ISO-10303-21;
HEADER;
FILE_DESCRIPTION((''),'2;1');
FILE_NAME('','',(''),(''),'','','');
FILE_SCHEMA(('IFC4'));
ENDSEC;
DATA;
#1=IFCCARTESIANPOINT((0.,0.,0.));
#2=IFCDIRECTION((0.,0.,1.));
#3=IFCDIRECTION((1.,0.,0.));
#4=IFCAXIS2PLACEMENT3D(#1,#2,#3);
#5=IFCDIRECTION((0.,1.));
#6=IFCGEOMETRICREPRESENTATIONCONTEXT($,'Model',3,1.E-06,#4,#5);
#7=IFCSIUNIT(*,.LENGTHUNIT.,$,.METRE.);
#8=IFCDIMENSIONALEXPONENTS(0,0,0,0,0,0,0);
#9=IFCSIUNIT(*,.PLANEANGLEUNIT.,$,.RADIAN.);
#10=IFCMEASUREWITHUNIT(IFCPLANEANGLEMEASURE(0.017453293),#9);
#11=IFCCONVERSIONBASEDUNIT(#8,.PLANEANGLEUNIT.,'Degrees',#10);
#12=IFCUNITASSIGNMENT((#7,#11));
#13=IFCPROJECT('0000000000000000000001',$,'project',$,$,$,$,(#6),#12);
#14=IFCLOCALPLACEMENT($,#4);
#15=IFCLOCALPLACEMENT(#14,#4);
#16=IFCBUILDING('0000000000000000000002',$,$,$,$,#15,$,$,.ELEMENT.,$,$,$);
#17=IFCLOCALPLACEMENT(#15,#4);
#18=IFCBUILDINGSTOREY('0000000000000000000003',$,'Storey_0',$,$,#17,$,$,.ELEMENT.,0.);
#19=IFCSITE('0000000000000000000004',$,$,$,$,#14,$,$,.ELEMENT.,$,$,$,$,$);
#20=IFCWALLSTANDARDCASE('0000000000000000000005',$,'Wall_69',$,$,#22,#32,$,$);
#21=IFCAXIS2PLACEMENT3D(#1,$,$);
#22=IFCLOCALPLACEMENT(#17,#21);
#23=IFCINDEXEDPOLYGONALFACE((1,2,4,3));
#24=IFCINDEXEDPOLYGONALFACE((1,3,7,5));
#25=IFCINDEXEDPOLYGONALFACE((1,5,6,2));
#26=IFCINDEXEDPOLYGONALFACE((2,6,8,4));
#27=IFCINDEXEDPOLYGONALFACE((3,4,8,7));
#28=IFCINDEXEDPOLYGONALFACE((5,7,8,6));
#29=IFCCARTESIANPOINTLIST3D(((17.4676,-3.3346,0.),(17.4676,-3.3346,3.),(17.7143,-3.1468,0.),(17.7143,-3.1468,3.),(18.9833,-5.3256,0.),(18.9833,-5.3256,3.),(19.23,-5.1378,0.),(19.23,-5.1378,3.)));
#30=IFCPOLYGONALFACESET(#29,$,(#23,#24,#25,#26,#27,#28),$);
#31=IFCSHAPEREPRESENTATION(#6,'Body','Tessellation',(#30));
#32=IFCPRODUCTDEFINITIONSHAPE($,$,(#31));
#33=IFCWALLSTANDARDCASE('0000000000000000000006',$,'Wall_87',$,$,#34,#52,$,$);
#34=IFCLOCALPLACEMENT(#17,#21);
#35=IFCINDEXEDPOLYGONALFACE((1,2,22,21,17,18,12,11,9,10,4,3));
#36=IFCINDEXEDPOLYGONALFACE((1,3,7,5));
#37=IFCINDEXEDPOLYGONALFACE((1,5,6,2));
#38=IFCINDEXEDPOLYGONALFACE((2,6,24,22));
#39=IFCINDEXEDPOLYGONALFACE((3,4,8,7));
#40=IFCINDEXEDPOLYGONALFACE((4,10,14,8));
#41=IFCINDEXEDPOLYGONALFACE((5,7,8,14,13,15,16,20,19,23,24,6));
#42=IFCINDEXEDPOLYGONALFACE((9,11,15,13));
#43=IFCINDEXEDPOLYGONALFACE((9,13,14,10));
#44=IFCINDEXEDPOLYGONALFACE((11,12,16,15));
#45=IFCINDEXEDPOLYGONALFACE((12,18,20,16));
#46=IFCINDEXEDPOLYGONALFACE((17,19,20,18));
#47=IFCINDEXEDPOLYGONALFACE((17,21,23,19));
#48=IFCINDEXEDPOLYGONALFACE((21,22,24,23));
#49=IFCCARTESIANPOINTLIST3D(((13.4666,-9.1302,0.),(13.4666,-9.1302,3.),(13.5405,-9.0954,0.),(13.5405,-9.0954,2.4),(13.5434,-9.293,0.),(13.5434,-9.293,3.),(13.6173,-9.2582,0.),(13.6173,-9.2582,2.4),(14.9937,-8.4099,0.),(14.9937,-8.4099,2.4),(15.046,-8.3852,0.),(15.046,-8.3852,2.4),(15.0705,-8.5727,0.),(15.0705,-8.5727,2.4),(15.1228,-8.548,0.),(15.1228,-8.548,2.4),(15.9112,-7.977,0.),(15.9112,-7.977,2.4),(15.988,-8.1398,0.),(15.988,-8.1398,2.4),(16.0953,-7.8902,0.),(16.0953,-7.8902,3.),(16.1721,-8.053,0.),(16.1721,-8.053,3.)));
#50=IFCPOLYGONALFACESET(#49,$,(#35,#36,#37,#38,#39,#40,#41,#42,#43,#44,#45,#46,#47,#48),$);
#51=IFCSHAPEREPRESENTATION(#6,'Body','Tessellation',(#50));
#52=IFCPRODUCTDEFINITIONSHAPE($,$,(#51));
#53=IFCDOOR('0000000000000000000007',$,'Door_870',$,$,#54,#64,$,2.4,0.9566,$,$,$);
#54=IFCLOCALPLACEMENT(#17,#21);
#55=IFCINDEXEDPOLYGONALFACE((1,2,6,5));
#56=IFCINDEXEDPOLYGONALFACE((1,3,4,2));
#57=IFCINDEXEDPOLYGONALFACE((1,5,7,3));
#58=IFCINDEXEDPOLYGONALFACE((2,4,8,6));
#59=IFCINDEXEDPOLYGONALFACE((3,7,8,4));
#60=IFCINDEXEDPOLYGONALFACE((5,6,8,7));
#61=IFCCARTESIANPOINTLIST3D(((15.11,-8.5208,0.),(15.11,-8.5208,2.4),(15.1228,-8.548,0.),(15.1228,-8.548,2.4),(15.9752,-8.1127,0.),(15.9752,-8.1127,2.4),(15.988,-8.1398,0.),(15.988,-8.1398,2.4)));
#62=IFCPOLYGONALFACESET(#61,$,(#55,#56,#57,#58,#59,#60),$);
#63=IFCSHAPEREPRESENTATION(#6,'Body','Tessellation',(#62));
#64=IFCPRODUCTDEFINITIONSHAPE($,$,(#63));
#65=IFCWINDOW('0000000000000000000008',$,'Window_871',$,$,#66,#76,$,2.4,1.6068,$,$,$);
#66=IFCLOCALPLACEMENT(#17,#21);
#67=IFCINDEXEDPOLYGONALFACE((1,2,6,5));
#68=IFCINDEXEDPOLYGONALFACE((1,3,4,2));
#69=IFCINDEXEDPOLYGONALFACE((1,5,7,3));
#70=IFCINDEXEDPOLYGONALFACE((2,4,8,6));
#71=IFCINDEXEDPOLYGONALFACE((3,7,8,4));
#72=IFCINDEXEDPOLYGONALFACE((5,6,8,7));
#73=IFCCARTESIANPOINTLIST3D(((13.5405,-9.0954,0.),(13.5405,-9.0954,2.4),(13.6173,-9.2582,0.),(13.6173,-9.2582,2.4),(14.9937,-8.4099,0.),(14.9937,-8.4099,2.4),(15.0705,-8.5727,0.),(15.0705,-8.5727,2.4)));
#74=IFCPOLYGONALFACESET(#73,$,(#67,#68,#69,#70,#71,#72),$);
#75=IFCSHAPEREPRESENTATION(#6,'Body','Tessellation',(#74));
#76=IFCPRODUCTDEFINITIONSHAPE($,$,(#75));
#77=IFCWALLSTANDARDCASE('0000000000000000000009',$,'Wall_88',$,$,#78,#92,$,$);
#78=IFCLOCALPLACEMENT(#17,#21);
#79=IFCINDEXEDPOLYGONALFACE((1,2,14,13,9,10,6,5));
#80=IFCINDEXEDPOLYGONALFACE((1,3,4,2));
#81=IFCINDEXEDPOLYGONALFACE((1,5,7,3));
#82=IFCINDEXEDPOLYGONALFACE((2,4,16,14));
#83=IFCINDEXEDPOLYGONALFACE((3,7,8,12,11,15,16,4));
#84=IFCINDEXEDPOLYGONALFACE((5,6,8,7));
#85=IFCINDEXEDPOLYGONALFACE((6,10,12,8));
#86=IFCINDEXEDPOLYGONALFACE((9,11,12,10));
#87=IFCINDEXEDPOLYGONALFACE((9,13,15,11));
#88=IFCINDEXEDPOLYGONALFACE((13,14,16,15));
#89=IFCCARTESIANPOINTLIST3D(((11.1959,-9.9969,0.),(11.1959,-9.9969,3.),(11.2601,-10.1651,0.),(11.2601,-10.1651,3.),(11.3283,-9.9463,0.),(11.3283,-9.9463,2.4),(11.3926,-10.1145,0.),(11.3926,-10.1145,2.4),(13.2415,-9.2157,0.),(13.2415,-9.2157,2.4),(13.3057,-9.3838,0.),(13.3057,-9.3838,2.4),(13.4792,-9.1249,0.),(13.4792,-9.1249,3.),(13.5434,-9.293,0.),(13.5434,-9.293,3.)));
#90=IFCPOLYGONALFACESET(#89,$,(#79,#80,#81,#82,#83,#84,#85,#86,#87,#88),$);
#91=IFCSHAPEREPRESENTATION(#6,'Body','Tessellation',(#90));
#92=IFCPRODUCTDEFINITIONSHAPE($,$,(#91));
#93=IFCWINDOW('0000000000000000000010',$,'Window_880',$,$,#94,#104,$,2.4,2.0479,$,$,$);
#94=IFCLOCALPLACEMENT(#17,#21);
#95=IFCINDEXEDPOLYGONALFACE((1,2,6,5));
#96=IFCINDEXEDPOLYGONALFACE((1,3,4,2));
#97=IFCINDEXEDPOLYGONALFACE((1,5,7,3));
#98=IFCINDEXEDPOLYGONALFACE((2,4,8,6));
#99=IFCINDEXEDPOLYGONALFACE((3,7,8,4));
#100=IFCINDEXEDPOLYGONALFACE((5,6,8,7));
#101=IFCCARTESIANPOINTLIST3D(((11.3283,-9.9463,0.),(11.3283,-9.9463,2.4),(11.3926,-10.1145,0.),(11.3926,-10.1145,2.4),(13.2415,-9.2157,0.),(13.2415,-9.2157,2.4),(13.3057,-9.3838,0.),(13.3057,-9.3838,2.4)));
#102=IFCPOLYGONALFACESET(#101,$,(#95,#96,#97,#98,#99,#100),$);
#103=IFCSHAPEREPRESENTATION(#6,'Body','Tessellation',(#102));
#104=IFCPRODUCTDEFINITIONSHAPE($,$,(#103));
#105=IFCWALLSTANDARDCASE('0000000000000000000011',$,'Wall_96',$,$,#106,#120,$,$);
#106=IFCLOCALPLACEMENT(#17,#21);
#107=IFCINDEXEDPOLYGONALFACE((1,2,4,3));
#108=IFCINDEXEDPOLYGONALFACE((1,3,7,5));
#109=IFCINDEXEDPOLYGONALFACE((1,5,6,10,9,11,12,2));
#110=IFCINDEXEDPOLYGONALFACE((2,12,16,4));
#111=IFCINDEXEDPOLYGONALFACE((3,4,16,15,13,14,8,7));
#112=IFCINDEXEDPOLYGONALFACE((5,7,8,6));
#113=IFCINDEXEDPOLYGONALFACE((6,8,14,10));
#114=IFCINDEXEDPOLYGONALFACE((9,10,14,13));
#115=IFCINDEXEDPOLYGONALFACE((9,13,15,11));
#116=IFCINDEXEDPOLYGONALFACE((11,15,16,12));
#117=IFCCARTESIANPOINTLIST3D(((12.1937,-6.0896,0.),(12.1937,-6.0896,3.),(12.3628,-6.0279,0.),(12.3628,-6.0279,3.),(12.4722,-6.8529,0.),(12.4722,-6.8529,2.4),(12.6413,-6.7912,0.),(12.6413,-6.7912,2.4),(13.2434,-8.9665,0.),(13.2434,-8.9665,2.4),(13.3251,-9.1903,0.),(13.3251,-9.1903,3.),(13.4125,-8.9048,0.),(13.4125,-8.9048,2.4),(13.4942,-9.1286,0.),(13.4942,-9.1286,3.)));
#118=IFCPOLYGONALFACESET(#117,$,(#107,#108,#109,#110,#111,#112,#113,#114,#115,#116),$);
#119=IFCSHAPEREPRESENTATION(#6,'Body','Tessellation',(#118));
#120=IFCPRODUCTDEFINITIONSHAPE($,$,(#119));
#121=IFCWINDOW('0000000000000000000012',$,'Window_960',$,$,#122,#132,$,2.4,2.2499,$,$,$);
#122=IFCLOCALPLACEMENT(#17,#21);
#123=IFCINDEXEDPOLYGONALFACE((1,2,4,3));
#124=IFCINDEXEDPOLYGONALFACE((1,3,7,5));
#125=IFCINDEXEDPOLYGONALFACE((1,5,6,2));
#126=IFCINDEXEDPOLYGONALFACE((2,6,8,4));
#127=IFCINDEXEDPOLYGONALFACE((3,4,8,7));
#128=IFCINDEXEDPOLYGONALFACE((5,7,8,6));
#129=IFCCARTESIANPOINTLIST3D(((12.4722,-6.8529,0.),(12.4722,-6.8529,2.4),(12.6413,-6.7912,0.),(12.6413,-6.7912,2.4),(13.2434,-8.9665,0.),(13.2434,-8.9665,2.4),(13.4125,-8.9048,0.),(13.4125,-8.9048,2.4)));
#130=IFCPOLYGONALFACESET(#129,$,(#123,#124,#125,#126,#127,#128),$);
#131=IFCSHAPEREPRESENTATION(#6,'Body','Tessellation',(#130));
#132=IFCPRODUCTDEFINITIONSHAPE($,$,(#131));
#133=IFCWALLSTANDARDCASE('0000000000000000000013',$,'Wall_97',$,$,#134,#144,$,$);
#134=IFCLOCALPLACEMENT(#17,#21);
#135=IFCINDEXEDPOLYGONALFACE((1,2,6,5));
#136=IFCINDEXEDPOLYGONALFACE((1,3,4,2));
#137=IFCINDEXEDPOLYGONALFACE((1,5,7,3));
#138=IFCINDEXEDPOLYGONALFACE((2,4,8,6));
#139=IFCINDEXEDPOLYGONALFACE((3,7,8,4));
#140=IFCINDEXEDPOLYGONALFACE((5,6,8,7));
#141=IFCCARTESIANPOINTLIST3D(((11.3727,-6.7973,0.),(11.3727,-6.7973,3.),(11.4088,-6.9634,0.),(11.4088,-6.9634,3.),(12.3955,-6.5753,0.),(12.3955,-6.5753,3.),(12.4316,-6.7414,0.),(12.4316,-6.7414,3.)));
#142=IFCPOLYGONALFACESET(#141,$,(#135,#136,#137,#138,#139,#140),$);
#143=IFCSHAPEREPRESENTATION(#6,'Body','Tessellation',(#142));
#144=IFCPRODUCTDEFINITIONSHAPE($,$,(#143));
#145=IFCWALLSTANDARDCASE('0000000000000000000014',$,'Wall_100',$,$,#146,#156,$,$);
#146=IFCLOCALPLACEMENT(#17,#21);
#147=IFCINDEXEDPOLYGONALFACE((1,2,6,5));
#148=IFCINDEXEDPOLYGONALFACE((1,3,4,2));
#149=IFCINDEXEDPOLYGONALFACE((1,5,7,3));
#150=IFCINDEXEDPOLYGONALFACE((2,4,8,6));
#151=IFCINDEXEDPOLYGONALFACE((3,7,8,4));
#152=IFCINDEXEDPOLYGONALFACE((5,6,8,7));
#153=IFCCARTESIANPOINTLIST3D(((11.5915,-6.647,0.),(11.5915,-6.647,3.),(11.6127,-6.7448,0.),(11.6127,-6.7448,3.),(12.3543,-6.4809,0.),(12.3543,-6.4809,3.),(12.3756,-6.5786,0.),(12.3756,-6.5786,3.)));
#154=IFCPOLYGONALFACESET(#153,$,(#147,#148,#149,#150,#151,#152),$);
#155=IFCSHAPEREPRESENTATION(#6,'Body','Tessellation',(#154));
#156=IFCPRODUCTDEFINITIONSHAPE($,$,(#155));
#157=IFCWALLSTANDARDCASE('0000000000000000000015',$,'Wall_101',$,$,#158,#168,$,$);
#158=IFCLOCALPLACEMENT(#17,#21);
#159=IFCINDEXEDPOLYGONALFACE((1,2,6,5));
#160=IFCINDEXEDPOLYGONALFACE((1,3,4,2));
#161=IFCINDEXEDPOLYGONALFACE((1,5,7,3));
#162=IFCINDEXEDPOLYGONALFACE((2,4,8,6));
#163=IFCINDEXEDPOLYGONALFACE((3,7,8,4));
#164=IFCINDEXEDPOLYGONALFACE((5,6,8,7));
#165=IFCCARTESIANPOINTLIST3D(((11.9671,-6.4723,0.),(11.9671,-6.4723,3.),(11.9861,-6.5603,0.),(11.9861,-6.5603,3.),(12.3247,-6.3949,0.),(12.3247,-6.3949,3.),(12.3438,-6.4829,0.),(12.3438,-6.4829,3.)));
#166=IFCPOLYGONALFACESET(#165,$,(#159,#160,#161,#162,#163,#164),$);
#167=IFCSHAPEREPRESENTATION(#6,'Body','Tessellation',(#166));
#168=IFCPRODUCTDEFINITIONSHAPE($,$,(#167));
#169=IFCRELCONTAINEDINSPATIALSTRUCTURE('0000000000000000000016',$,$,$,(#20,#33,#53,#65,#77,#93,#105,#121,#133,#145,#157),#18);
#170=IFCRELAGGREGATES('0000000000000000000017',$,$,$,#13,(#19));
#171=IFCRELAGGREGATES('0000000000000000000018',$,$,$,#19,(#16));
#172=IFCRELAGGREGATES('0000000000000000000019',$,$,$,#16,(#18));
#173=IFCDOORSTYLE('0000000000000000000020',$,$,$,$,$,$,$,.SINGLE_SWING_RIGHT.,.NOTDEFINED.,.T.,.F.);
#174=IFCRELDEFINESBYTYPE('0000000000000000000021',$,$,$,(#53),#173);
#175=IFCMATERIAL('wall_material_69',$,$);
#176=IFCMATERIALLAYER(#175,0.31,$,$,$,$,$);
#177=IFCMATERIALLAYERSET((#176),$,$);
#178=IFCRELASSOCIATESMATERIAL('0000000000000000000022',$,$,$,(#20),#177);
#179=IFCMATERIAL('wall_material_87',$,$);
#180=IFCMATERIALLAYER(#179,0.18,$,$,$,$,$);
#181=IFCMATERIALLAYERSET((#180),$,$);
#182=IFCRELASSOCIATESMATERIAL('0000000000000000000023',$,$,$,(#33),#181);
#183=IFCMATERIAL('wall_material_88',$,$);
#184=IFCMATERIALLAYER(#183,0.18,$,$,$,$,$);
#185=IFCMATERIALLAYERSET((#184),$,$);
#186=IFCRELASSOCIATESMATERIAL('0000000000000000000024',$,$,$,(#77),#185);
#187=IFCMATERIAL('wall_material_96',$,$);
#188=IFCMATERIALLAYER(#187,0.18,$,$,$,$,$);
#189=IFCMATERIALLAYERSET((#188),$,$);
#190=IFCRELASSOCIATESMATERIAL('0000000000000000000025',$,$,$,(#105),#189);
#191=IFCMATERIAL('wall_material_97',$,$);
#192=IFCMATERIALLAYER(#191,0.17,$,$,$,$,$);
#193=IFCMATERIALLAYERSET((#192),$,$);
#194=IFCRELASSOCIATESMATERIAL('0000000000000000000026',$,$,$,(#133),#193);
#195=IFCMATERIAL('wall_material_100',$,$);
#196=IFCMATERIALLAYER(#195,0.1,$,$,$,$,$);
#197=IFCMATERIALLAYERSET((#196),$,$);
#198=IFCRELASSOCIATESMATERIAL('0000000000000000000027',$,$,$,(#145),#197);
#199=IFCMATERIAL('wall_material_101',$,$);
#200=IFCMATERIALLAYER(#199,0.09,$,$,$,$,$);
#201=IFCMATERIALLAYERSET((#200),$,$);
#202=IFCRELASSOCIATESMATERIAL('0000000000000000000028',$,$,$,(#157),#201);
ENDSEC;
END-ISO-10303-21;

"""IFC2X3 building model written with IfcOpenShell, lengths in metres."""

from ifc_helpers import new_model, entity, si_unit, converted_unit, direction, frame, frame_2d, origin_with_axes, place, context, project, spatial, polyline, rectangle, outline, extrude, material, layer, layer_set, layer_usage, type_object, element, fill, save


model = new_model("IFC2X3")

# Units and contexts
model_context = context("Model", 3, precision=1e-06, world=origin_with_axes(), true_north=direction((0.0, 1.0)))
ifc_project = project(units=[si_unit("LENGTHUNIT", "METRE"), converted_unit("PLANEANGLEUNIT", "Degrees", entity("IfcPlaneAngleMeasure", 0.017453293), si_unit("PLANEANGLEUNIT", "RADIAN"), dimensions=[0, 0, 0, 0, 0, 0, 0])], contexts=[model_context])

# Site, building, storey
site_placement = place(None, origin_with_axes())
site = spatial("IfcSite", under=ifc_project, at=site_placement, CompositionType="ELEMENT")
building_placement = place(site_placement, origin_with_axes())
building = spatial("IfcBuilding", under=site, at=building_placement, CompositionType="ELEMENT")
storey_placement = place(building_placement, origin_with_axes())
storey = spatial("IfcBuildingStorey", under=building, at=storey_placement, Name="Storey_0", CompositionType="ELEMENT", Elevation=0.0)

# Wall
ifc_material_1 = material(Name="wall_material_69")
ifc_layer_1 = layer(ifc_material_1, 0.31)
ifc_layer_set_1 = layer_set([ifc_layer_1])
ifc_layer_usage_1 = layer_usage(ifc_layer_set_1, "AXIS2", "NEGATIVE", 0.0)
wall_1_placement = place(storey_placement, frame((17.7143, -3.1468, 0.0), z_axis=(0.0, 0.0, 1.0), x_axis=(0.605711, -0.795685, 0.0)))
element("IfcWallStandardCase", 1, at=wall_1_placement, inside=storey, material=ifc_layer_usage_1, Name="Wall_69", context=model_context, shape_type="SweptSolid", body=[
    extrude(outline(polyline([(0.0, 0.0), (2.5023, 0.0), (2.5023, -0.31), (0.0, -0.31), (0.0, 0.0)])), origin_with_axes(), (0.0, 0.0, 1.0), 3.0),
])

# Wall, openings, door, window
ifc_material_2 = material(Name="wall_material_87")
ifc_layer_2 = layer(ifc_material_2, 0.18)
ifc_layer_set_2 = layer_set([ifc_layer_2])
ifc_layer_usage_2 = layer_usage(ifc_layer_set_2, "AXIS2", "POSITIVE", 0.0)
wall_2_placement = place(storey_placement, frame((16.0953, -7.8902, 0.0), z_axis=(0.0, 0.0, 1.0), x_axis=(-0.904416, -0.426652, 0.0)))
wall_2 = element("IfcWallStandardCase", 2, at=wall_2_placement, inside=storey, material=ifc_layer_usage_2, Name="Wall_87", context=model_context, shape_type="SweptSolid", body=[
    extrude(outline(polyline([(0.0, 0.18), (2.9065, 0.18), (2.9065, 0.0), (0.0, 0.0), (0.0, 0.18)])), origin_with_axes(), (0.0, 0.0, 1.0), 3.0),
])
opening_1_placement = place(wall_2_placement, frame((0.2036, 0.18, 0.0), z_axis=(0.0, 0.0, 1.0), x_axis=(1.0, 0.0, 0.0)))
opening_1 = element("IfcOpeningElement", 3, at=opening_1_placement, cuts=wall_2, context=model_context, shape_type="SweptSolid", body=[
    extrude(rectangle(XDim=0.9566, YDim=2.4, at=frame_2d((1.2, -0.4783), x_axis=(0.0, 1.0))), frame((0.0, 0.01, 0.0), z_axis=(0.0, -1.0, 0.0), x_axis=(0.0, 0.0, 1.0)), (0.0, 0.0, 1.0), 0.2),
])
opening_2_placement = place(wall_2_placement, frame((1.218, 0.18, 0.0), z_axis=(0.0, 0.0, 1.0), x_axis=(1.0, 0.0, 0.0)))
opening_2 = element("IfcOpeningElement", 4, at=opening_2_placement, cuts=wall_2, context=model_context, shape_type="SweptSolid", body=[
    extrude(rectangle(XDim=1.6068, YDim=2.4, at=frame_2d((1.2, -0.8034), x_axis=(0.0, 1.0))), frame((0.0, 0.01, 0.0), z_axis=(0.0, -1.0, 0.0), x_axis=(0.0, 0.0, 1.0)), (0.0, 0.0, 1.0), 0.2),
])
door_style_1 = type_object("IfcDoorStyle", ConstructionType="NOTDEFINED", OperationType="SINGLE_SWING_RIGHT", ParameterTakesPrecedence=True, Sizeable=False)
door_1_placement = place(storey_placement, origin_with_axes())
door_1 = element("IfcDoor", 5, at=door_1_placement, inside=storey, type_object=door_style_1, Name="Door_870", OverallHeight=2.4, OverallWidth=0.9566, context=model_context, shape_type="SweptSolid", body=[
    extrude(outline(polyline([(15.988, -8.1398), (15.1228, -8.548), (15.11, -8.5208), (15.9752, -8.1127), (15.988, -8.1398)])), origin_with_axes(), (0.0, 0.0, 1.0), 2.4),
])
fill(opening_1, door_1)
window_1_placement = place(storey_placement, origin_with_axes())
window_1 = element("IfcWindow", 6, at=window_1_placement, inside=storey, Name="Window_871", OverallHeight=2.4, OverallWidth=1.6068, context=model_context, shape_type="SweptSolid", body=[
    extrude(outline(polyline([(15.0705, -8.5727), (13.6173, -9.2582), (13.5405, -9.0954), (14.9937, -8.4099), (15.0705, -8.5727)])), origin_with_axes(), (0.0, 0.0, 1.0), 2.4),
])
fill(opening_2, window_1)

# Walls, openings, windows
ifc_material_3 = material(Name="wall_material_88")
ifc_layer_3 = layer(ifc_material_3, 0.18)
ifc_layer_set_3 = layer_set([ifc_layer_3])
ifc_layer_usage_3 = layer_usage(ifc_layer_set_3, "AXIS2", "POSITIVE", 0.0)
wall_3_placement = place(storey_placement, frame((13.4792, -9.1249, 0.0), z_axis=(0.0, 0.0, 1.0), x_axis=(-0.934191, -0.356774, 0.0)))
wall_3 = element("IfcWallStandardCase", 7, at=wall_3_placement, inside=storey, material=ifc_layer_usage_3, Name="Wall_88", context=model_context, shape_type="SweptSolid", body=[
    extrude(outline(polyline([(0.0, 0.18), (2.4442, 0.18), (2.4442, 0.0), (0.0, 0.0), (0.0, 0.18)])), origin_with_axes(), (0.0, 0.0, 1.0), 3.0),
])
opening_3_placement = place(wall_3_placement, frame((0.2544, 0.18, 0.0), z_axis=(0.0, 0.0, 1.0), x_axis=(1.0, 0.0, 0.0)))
opening_3 = element("IfcOpeningElement", 8, at=opening_3_placement, cuts=wall_3, context=model_context, shape_type="SweptSolid", body=[
    extrude(rectangle(XDim=2.0479, YDim=2.4, at=frame_2d((1.2, -1.024), x_axis=(0.0, 1.0))), frame((0.0, 0.01, 0.0), z_axis=(0.0, -1.0, 0.0), x_axis=(0.0, 0.0, 1.0)), (0.0, 0.0, 1.0), 0.2),
])
window_2_placement = place(storey_placement, origin_with_axes())
window_2 = element("IfcWindow", 9, at=window_2_placement, inside=storey, Name="Window_880", OverallHeight=2.4, OverallWidth=2.0479, context=model_context, shape_type="SweptSolid", body=[
    extrude(outline(polyline([(13.3057, -9.3838), (11.3926, -10.1145), (11.3283, -9.9463), (13.2415, -9.2157), (13.3057, -9.3838)])), origin_with_axes(), (0.0, 0.0, 1.0), 2.4),
])
fill(opening_3, window_2)
ifc_material_4 = material(Name="wall_material_96")
ifc_layer_4 = layer(ifc_material_4, 0.18)
ifc_layer_set_4 = layer_set([ifc_layer_4])
ifc_layer_usage_4 = layer_usage(ifc_layer_set_4, "AXIS2", "NEGATIVE", 0.0)
wall_4_placement = place(storey_placement, frame((12.3628, -6.0279, 0.0), z_axis=(0.0, 0.0, 1.0), x_axis=(0.342762, -0.939422, 0.0)))
wall_4 = element("IfcWallStandardCase", 10, at=wall_4_placement, inside=storey, material=ifc_layer_usage_4, Name="Wall_96", context=model_context, shape_type="SweptSolid", body=[
    extrude(outline(polyline([(0.0, 0.0), (3.3007, 0.0), (3.3007, -0.18), (0.0, -0.18), (0.0, 0.0)])), origin_with_axes(), (0.0, 0.0, 1.0), 3.0),
])
opening_4_placement = place(wall_4_placement, frame((0.8126, 0.0, 0.0), z_axis=(0.0, 0.0, 1.0), x_axis=(1.0, 0.0, 0.0)))
opening_4 = element("IfcOpeningElement", 11, at=opening_4_placement, cuts=wall_4, context=model_context, shape_type="SweptSolid", body=[
    extrude(rectangle(XDim=2.2499, YDim=2.4, at=frame_2d((1.2, -1.1249), x_axis=(0.0, 1.0))), frame((0.0, 0.01, 0.0), z_axis=(0.0, -1.0, 0.0), x_axis=(0.0, 0.0, 1.0)), (0.0, 0.0, 1.0), 0.2),
])
window_3_placement = place(storey_placement, origin_with_axes())
window_3 = element("IfcWindow", 12, at=window_3_placement, inside=storey, Name="Window_960", OverallHeight=2.4, OverallWidth=2.2499, context=model_context, shape_type="SweptSolid", body=[
    extrude(outline(polyline([(12.6413, -6.7912), (13.4125, -8.9048), (13.2434, -8.9665), (12.4722, -6.8529), (12.6413, -6.7912)])), origin_with_axes(), (0.0, 0.0, 1.0), 2.4),
])
fill(opening_4, window_3)

# Walls
ifc_material_5 = material(Name="wall_material_97")
ifc_layer_5 = layer(ifc_material_5, 0.17)
ifc_layer_set_5 = layer_set([ifc_layer_5])
ifc_layer_usage_5 = layer_usage(ifc_layer_set_5, "AXIS2", "POSITIVE", 0.0)
wall_5_placement = place(storey_placement, frame((11.4088, -6.9634, 0.0), z_axis=(0.0, 0.0, 1.0), x_axis=(0.977251, 0.212087, 0.0)))
element("IfcWallStandardCase", 13, at=wall_5_placement, inside=storey, material=ifc_layer_usage_5, Name="Wall_97", context=model_context, shape_type="SweptSolid", body=[
    extrude(outline(polyline([(0.0, 0.17), (1.0466, 0.17), (1.0466, 0.0), (0.0, 0.0), (0.0, 0.17)])), origin_with_axes(), (0.0, 0.0, 1.0), 3.0),
])
ifc_material_6 = material(Name="wall_material_100")
ifc_layer_6 = layer(ifc_material_6, 0.1)
ifc_layer_set_6 = layer_set([ifc_layer_6])
ifc_layer_usage_6 = layer_usage(ifc_layer_set_6, "AXIS2", "POSITIVE", 0.0)
wall_6_placement = place(storey_placement, frame((11.6127, -6.7448, 0.0), z_axis=(0.0, 0.0, 1.0), x_axis=(0.977088, 0.212835, 0.0)))
element("IfcWallStandardCase", 14, at=wall_6_placement, inside=storey, material=ifc_layer_usage_6, Name="Wall_100", context=model_context, shape_type="SweptSolid", body=[
    extrude(outline(polyline([(0.0, 0.1), (0.7807, 0.1), (0.7807, 0.0), (0.0, 0.0), (0.0, 0.1)])), origin_with_axes(), (0.0, 0.0, 1.0), 3.0),
])
ifc_material_7 = material(Name="wall_material_101")
ifc_layer_7 = layer(ifc_material_7, 0.09)
ifc_layer_set_7 = layer_set([ifc_layer_7])
ifc_layer_usage_7 = layer_usage(ifc_layer_set_7, "AXIS2", "POSITIVE", 0.0)
wall_7_placement = place(storey_placement, frame((11.9861, -6.5603, 0.0), z_axis=(0.0, 0.0, 1.0), x_axis=(0.977369, 0.211543, 0.0)))
element("IfcWallStandardCase", 15, at=wall_7_placement, inside=storey, material=ifc_layer_usage_7, Name="Wall_101", context=model_context, shape_type="SweptSolid", body=[
    extrude(outline(polyline([(0.0, 0.09), (0.3659, 0.09), (0.3659, 0.0), (0.0, 0.0), (0.0, 0.09)])), origin_with_axes(), (0.0, 0.0, 1.0), 3.0),
])

save(model, "model.ifc")
